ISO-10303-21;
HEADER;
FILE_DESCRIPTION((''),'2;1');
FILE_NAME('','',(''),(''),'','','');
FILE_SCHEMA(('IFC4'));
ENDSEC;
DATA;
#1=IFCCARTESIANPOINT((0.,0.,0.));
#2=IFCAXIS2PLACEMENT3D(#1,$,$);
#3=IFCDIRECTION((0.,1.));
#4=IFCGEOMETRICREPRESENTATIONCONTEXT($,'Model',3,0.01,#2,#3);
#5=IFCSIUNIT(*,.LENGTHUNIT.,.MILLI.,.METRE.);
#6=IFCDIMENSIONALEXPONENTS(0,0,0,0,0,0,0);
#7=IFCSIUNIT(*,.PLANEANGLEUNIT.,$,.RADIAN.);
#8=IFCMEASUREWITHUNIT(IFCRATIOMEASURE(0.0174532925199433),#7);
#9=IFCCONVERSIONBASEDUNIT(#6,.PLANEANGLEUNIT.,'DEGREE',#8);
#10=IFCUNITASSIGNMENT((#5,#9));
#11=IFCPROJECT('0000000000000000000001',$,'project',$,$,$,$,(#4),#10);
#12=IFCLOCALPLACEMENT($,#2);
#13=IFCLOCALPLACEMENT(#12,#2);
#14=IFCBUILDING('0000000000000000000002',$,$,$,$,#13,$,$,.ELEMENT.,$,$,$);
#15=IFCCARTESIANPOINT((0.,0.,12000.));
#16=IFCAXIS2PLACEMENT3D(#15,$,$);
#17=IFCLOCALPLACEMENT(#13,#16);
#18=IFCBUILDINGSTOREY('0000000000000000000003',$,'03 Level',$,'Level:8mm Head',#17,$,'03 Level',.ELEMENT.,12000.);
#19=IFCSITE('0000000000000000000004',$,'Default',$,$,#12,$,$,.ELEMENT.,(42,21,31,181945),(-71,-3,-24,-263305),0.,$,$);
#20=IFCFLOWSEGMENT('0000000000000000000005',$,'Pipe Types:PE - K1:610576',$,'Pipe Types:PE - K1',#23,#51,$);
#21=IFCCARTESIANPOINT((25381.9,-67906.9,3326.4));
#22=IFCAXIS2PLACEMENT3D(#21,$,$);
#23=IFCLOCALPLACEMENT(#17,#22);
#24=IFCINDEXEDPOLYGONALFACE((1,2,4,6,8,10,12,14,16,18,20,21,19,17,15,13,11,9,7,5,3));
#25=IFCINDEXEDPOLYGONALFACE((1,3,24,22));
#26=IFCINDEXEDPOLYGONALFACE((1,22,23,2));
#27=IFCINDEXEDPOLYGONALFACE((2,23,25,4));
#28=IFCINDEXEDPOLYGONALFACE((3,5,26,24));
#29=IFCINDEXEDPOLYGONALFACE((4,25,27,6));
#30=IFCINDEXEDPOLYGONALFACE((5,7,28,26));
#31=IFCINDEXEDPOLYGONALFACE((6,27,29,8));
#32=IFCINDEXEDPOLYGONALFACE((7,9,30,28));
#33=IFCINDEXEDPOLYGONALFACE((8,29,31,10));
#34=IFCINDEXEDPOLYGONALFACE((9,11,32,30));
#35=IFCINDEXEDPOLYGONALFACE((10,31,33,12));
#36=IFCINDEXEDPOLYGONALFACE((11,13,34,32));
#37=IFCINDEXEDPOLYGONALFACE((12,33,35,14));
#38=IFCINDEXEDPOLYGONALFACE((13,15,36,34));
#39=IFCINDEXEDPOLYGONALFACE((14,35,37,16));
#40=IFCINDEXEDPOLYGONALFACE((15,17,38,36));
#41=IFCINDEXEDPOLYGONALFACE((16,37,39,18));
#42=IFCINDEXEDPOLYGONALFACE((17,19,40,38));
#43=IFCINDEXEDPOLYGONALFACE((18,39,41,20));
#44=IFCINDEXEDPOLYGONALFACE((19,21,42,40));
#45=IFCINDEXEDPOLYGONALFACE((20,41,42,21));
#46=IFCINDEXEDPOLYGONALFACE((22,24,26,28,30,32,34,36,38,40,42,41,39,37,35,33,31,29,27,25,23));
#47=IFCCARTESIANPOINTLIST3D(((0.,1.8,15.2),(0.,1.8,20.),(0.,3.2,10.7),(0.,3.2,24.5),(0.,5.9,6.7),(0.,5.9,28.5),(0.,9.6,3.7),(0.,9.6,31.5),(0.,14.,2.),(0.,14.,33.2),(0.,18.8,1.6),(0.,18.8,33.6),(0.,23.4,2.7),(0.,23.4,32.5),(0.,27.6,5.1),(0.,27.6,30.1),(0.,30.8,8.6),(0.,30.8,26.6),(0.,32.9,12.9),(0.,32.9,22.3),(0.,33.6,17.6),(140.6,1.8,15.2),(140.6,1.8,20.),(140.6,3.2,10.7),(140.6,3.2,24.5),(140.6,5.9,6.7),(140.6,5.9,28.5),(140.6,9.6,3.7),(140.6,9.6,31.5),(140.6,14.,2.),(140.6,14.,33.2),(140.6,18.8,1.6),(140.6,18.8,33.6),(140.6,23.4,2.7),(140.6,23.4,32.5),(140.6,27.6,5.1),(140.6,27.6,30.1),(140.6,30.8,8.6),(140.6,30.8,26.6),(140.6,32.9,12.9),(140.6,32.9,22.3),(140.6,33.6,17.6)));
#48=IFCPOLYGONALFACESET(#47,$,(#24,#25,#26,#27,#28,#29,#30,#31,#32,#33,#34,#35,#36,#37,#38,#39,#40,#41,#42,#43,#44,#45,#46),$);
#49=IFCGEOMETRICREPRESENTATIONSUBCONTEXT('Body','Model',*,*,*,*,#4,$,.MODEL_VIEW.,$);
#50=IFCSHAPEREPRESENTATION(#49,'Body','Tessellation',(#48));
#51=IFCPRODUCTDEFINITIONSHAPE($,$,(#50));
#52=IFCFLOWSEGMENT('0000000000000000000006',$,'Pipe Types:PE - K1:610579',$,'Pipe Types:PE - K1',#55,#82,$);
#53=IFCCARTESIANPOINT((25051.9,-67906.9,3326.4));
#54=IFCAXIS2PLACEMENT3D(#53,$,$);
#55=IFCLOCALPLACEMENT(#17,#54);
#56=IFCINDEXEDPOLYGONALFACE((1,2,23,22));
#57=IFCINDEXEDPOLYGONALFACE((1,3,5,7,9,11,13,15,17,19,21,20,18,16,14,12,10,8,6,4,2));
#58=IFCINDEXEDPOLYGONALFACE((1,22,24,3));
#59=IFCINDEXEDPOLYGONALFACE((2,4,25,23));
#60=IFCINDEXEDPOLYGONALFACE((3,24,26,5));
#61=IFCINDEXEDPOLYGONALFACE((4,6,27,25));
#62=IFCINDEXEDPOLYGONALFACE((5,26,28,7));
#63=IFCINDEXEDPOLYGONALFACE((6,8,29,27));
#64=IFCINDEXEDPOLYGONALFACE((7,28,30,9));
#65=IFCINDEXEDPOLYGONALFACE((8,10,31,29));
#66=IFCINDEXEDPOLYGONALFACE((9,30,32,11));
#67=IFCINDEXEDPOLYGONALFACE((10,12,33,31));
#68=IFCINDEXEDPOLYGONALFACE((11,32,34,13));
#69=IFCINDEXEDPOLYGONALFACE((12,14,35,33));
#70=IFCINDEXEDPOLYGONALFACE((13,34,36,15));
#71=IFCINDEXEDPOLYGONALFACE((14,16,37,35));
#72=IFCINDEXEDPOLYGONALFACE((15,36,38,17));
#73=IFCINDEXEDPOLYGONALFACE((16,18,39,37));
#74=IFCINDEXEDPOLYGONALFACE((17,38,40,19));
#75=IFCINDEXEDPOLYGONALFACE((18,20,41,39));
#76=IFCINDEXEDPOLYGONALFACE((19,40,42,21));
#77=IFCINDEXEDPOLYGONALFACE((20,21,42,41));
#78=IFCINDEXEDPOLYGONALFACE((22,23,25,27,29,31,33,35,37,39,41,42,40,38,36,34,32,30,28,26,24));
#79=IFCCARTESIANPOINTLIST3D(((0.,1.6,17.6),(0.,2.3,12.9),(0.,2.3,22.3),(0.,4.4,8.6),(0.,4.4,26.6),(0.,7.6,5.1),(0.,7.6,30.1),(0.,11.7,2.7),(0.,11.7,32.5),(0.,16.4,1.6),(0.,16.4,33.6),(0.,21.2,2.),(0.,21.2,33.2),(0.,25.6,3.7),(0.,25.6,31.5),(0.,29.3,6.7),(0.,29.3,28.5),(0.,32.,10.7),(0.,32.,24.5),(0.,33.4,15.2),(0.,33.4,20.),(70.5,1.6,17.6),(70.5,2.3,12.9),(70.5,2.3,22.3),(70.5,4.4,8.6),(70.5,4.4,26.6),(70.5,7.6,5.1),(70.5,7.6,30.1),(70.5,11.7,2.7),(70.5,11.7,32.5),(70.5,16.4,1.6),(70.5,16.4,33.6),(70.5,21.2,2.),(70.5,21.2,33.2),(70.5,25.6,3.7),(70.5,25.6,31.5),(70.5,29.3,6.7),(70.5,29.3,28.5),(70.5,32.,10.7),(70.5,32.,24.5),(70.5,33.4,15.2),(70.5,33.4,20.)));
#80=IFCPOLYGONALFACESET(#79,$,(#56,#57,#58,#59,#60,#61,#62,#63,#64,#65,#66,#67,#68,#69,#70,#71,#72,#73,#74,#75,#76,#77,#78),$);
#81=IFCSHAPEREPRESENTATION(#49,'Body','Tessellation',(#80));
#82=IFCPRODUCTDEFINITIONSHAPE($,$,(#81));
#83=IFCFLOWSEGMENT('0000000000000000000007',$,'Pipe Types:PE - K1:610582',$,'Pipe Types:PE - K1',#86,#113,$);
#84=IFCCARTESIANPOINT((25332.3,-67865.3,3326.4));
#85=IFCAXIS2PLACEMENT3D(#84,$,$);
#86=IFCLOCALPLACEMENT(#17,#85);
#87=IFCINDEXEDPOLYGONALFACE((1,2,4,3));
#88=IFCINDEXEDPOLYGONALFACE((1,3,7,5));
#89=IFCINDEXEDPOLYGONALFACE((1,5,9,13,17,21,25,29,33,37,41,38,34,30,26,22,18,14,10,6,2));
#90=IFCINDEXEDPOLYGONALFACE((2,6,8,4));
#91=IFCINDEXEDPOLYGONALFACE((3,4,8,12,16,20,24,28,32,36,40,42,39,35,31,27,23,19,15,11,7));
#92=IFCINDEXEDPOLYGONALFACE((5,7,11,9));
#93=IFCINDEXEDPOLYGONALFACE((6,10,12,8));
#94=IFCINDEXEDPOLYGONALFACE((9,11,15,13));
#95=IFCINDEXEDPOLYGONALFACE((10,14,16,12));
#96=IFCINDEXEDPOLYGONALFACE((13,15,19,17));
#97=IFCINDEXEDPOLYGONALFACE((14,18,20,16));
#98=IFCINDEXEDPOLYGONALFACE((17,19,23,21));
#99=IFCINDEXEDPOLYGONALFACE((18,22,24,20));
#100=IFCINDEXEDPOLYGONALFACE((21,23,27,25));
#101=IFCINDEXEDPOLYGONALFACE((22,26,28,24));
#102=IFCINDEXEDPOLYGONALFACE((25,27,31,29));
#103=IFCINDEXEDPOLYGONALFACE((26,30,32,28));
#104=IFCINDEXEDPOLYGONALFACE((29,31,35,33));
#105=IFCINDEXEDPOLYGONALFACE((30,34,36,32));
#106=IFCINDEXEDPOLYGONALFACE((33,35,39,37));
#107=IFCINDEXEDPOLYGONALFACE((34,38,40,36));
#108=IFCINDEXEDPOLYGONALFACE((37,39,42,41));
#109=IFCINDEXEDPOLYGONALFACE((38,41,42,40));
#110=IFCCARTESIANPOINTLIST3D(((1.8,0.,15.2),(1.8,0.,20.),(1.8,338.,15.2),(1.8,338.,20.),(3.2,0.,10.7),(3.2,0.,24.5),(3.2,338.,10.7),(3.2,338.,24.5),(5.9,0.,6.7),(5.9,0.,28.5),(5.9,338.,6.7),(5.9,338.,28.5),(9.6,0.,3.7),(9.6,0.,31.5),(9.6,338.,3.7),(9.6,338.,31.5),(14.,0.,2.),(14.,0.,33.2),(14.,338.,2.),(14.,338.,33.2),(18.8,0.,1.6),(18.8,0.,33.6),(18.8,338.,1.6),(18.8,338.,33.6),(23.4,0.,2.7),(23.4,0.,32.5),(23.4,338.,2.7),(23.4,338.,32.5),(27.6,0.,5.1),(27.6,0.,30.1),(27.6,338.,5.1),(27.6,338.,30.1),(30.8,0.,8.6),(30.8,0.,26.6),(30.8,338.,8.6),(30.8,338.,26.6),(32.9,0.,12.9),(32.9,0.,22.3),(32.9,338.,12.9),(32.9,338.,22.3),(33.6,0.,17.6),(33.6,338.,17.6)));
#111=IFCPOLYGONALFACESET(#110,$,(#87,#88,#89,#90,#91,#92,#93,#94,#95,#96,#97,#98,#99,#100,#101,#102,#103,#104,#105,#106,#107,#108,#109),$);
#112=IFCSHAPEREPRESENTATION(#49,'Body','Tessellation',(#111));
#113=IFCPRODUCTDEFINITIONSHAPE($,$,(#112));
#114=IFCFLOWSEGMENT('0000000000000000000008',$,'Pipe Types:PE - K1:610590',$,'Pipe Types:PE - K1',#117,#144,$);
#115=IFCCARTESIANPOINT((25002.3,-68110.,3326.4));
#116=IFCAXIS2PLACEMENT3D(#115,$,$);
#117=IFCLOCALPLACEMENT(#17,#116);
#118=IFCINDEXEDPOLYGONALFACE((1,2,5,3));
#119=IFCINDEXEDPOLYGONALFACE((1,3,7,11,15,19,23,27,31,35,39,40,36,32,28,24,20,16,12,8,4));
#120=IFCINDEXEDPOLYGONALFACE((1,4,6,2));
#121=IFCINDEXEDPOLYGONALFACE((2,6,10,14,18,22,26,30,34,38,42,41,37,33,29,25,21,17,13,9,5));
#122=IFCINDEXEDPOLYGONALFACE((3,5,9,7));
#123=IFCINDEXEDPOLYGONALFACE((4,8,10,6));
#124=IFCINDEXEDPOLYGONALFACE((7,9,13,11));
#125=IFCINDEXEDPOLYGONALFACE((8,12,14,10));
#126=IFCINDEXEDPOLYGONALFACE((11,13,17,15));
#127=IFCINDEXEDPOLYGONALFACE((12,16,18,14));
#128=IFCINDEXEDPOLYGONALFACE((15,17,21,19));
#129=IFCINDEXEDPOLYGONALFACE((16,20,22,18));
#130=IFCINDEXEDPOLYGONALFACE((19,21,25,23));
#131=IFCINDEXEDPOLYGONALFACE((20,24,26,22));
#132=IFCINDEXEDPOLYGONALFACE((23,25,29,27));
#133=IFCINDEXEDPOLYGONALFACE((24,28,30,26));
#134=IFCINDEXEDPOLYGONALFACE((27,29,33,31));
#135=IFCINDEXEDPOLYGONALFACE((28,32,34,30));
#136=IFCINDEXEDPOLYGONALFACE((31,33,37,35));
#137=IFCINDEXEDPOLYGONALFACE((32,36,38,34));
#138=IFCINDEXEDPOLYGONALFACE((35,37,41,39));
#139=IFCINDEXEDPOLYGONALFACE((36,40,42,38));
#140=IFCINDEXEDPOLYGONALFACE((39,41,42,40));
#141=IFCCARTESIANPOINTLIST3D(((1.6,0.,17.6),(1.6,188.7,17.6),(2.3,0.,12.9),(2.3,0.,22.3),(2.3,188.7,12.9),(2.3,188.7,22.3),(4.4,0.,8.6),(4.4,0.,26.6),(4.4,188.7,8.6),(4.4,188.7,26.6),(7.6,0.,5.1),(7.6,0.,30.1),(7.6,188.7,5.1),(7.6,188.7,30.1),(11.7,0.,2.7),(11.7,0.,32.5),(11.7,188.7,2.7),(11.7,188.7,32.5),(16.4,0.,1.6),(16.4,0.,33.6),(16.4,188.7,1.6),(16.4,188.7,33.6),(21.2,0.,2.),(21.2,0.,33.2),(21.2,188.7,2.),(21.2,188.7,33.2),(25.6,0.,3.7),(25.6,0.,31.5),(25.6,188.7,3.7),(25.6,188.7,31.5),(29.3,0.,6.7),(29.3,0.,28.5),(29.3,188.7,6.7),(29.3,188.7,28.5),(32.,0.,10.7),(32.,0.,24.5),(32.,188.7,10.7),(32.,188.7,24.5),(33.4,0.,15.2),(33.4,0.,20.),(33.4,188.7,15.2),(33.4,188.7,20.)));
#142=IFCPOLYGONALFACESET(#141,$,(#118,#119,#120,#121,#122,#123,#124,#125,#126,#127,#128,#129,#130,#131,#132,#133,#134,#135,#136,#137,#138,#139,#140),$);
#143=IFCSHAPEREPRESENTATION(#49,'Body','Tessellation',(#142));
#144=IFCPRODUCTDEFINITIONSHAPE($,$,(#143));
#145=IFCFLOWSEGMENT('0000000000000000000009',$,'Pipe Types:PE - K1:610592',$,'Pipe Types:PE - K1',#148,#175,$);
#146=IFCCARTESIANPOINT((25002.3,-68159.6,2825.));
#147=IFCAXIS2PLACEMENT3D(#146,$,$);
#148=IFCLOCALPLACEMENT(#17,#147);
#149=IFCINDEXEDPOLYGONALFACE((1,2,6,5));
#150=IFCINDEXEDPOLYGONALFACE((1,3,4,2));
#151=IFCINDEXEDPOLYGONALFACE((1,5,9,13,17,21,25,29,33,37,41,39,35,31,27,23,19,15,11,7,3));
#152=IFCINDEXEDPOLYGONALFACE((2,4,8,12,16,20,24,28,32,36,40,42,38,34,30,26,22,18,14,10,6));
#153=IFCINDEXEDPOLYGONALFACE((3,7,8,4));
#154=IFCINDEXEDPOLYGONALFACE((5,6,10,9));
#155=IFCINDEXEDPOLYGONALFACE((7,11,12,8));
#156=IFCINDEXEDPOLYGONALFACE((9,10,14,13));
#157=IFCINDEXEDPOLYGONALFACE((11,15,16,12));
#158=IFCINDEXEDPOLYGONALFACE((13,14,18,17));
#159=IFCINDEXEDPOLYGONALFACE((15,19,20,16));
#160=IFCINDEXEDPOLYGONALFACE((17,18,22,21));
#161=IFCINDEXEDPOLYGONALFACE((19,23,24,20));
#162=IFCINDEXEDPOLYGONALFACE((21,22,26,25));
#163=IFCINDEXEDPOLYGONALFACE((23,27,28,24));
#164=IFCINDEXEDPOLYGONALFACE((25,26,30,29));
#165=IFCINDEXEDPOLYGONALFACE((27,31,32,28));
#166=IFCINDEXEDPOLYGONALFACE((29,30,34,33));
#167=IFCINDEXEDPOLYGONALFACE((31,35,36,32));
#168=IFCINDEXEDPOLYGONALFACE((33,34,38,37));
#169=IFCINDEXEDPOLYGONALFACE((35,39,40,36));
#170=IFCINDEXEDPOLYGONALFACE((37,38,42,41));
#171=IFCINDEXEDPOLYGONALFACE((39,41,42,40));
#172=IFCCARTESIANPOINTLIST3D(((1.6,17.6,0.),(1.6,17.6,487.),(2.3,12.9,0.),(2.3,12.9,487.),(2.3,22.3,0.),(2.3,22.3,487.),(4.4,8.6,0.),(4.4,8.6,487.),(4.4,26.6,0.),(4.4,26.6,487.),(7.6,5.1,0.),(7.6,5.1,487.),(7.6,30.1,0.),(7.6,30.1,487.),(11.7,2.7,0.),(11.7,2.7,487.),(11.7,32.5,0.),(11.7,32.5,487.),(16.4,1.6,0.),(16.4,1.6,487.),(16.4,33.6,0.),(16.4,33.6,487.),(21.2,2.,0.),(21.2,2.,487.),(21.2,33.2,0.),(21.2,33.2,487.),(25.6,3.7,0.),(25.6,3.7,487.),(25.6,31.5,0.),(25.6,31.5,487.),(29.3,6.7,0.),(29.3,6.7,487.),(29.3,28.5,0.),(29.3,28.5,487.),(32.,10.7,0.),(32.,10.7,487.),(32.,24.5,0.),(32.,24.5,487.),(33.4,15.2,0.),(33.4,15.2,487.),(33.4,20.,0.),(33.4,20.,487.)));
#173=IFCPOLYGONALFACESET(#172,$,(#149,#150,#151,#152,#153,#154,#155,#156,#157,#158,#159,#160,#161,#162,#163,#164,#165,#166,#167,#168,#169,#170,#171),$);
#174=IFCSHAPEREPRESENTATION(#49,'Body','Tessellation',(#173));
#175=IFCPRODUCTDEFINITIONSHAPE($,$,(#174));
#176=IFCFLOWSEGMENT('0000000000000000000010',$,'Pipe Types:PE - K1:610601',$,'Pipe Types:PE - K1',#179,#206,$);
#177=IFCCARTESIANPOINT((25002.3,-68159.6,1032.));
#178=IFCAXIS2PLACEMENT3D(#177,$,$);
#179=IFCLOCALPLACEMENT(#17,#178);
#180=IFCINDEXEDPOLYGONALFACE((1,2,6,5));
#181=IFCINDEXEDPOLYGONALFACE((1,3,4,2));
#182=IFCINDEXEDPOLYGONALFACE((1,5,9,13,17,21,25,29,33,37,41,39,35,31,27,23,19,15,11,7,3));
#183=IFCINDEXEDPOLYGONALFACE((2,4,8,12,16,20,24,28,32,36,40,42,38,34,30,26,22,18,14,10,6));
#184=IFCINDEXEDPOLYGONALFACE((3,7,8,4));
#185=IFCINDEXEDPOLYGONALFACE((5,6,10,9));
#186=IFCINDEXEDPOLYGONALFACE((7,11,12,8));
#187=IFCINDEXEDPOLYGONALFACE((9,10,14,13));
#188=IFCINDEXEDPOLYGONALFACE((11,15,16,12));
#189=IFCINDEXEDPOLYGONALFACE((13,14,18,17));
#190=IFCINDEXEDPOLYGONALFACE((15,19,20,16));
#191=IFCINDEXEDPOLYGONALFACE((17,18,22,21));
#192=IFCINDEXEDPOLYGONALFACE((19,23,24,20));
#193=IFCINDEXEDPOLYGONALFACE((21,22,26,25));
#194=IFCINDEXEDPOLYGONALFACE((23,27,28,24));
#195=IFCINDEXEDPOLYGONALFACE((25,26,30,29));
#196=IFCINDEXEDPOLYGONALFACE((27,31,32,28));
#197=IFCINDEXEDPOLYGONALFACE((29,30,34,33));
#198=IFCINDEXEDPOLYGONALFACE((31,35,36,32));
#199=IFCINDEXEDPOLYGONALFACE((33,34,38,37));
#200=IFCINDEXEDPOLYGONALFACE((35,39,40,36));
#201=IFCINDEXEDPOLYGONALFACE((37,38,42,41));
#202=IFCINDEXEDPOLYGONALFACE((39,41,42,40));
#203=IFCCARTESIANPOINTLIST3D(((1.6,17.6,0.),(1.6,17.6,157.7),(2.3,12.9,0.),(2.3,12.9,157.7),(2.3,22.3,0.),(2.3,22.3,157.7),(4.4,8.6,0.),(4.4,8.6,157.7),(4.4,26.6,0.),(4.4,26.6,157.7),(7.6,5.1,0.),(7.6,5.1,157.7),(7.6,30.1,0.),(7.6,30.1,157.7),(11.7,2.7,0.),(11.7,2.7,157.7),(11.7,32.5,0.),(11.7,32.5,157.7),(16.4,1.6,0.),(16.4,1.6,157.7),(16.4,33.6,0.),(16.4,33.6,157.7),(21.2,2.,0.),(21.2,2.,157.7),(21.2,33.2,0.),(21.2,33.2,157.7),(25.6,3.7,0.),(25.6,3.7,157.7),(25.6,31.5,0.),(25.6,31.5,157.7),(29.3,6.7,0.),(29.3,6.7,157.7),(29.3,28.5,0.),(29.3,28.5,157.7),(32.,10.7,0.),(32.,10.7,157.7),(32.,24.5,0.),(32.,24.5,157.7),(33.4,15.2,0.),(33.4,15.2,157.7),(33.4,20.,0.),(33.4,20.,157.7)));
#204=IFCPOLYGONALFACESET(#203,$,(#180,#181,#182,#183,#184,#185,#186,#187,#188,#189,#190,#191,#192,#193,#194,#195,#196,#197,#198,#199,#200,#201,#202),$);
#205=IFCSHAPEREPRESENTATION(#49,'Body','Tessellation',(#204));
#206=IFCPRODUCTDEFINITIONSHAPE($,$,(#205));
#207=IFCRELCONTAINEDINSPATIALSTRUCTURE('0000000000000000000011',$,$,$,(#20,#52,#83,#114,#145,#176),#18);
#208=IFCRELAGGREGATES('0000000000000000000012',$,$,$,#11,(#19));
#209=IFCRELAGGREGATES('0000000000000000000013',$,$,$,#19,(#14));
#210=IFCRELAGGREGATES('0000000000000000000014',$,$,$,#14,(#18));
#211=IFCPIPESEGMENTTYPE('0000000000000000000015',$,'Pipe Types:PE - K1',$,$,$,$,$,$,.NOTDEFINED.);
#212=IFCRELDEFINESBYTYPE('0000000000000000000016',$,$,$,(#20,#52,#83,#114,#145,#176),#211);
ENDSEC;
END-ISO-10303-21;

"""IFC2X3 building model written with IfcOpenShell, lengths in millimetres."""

from ifc_helpers import new_model, entity, si_unit, converted_unit, direction, frame, frame_2d, origin, origin_2d_with_axis, place, context, subcontext, project, spatial, circle, extrude, type_object, element, save


model = new_model("IFC2X3")

# Units and contexts
model_context = context("Model", 3, precision=0.01, world=origin(), true_north=direction((0.0, 1.0)))
body_context = subcontext(model_context, "Body", "Model", "MODEL_VIEW")
ifc_project = project(units=[si_unit("LENGTHUNIT", "METRE", prefix="MILLI"), converted_unit("PLANEANGLEUNIT", "DEGREE", entity("IfcRatioMeasure", 0.0174532925199433), si_unit("PLANEANGLEUNIT", "RADIAN"), dimensions=[0, 0, 0, 0, 0, 0, 0])], contexts=[model_context])

# Site, building, storey
site_placement = place(None, origin())
site = spatial("IfcSite", under=ifc_project, at=site_placement, Name="Default", CompositionType="ELEMENT", RefLatitude=(42, 21, 31, 181945), RefLongitude=(-71, -3, -24, -263305), RefElevation=0.0)
building_placement = place(site_placement, origin())
building = spatial("IfcBuilding", under=site, at=building_placement, CompositionType="ELEMENT")
storey_placement = place(building_placement, frame((0.0, 0.0, 12000.0)))
storey = spatial("IfcBuildingStorey", under=building, at=storey_placement, Name="03 Level", ObjectType="Level:8mm Head", LongName="03 Level", CompositionType="ELEMENT", Elevation=12000.0)

# Flow segments
pipe_segment_type = type_object("IfcPipeSegmentType", Name="Pipe Types:PE - K1", PredefinedType="NOTDEFINED")
flow_segment_1_placement = place(storey_placement, frame((25381.9, -67906.9, 3326.4)))
element("IfcFlowSegment", 1, at=flow_segment_1_placement, inside=storey, type_object=pipe_segment_type, Name="Pipe Types:PE - K1:610576", ObjectType="Pipe Types:PE - K1", context=body_context, shape_type="SweptSolid", body=[
    extrude(circle(Radius=16.0, at=frame_2d((0.0, 0.0), x_axis=(1.0, 0.0))), frame((0.0, 17.6, 17.6), z_axis=(1.0, 0.0, 0.0), x_axis=(0.0, 1.0, 0.0)), (0.0, 0.0, 1.0), 140.6),
])
flow_segment_2_placement = place(storey_placement, frame((25051.9, -67906.9, 3326.4)))
element("IfcFlowSegment", 2, at=flow_segment_2_placement, inside=storey, type_object=pipe_segment_type, Name="Pipe Types:PE - K1:610579", ObjectType="Pipe Types:PE - K1", context=body_context, shape_type="SweptSolid", body=[
    extrude(circle(Radius=16.0, at=origin_2d_with_axis()), frame((0.0, 17.6, 17.6), z_axis=(1.0, 0.0, 0.0), x_axis=(0.0, -1.0, 0.0)), (0.0, 0.0, 1.0), 70.5),
])
flow_segment_3_placement = place(storey_placement, frame((25332.3, -67865.3, 3326.4)))
element("IfcFlowSegment", 3, at=flow_segment_3_placement, inside=storey, type_object=pipe_segment_type, Name="Pipe Types:PE - K1:610582", ObjectType="Pipe Types:PE - K1", context=body_context, shape_type="SweptSolid", body=[
    extrude(circle(Radius=16.0, at=origin_2d_with_axis()), frame((17.6, 0.0, 17.6), z_axis=(0.0, 1.0, 0.0), x_axis=(1.0, 0.0, 0.0)), (0.0, 0.0, 1.0), 338.0),
])
flow_segment_4_placement = place(storey_placement, frame((25002.3, -68110.0, 3326.4)))
element("IfcFlowSegment", 4, at=flow_segment_4_placement, inside=storey, type_object=pipe_segment_type, Name="Pipe Types:PE - K1:610590", ObjectType="Pipe Types:PE - K1", context=body_context, shape_type="SweptSolid", body=[
    extrude(circle(Radius=16.0, at=frame_2d((0.0, 0.0), x_axis=(1.0, 0.0))), frame((17.6, 0.0, 17.6), z_axis=(0.0, 1.0, 0.0), x_axis=(-1.0, 0.0, 0.0)), (0.0, 0.0, 1.0), 188.7),
])
flow_segment_5_placement = place(storey_placement, frame((25002.3, -68159.6, 2825.0)))
element("IfcFlowSegment", 5, at=flow_segment_5_placement, inside=storey, type_object=pipe_segment_type, Name="Pipe Types:PE - K1:610592", ObjectType="Pipe Types:PE - K1", context=body_context, shape_type="SweptSolid", body=[
    extrude(circle(Radius=16.0, at=origin_2d_with_axis()), frame((17.6, 17.6, 0.0), z_axis=(0.0, 0.0, 1.0), x_axis=(-1.0, 0.0, 0.0)), (0.0, 0.0, 1.0), 487.0),
])
flow_segment_6_placement = place(storey_placement, frame((25002.3, -68159.6, 1032.0)))
element("IfcFlowSegment", 6, at=flow_segment_6_placement, inside=storey, type_object=pipe_segment_type, Name="Pipe Types:PE - K1:610601", ObjectType="Pipe Types:PE - K1", context=body_context, shape_type="SweptSolid", body=[
    extrude(circle(Radius=16.0, at=origin_2d_with_axis()), frame((17.6, 17.6, 0.0), z_axis=(0.0, 0.0, 1.0), x_axis=(-1.0, 0.0, 0.0)), (0.0, 0.0, 1.0), 157.7),
])

save(model, "model.ifc")
